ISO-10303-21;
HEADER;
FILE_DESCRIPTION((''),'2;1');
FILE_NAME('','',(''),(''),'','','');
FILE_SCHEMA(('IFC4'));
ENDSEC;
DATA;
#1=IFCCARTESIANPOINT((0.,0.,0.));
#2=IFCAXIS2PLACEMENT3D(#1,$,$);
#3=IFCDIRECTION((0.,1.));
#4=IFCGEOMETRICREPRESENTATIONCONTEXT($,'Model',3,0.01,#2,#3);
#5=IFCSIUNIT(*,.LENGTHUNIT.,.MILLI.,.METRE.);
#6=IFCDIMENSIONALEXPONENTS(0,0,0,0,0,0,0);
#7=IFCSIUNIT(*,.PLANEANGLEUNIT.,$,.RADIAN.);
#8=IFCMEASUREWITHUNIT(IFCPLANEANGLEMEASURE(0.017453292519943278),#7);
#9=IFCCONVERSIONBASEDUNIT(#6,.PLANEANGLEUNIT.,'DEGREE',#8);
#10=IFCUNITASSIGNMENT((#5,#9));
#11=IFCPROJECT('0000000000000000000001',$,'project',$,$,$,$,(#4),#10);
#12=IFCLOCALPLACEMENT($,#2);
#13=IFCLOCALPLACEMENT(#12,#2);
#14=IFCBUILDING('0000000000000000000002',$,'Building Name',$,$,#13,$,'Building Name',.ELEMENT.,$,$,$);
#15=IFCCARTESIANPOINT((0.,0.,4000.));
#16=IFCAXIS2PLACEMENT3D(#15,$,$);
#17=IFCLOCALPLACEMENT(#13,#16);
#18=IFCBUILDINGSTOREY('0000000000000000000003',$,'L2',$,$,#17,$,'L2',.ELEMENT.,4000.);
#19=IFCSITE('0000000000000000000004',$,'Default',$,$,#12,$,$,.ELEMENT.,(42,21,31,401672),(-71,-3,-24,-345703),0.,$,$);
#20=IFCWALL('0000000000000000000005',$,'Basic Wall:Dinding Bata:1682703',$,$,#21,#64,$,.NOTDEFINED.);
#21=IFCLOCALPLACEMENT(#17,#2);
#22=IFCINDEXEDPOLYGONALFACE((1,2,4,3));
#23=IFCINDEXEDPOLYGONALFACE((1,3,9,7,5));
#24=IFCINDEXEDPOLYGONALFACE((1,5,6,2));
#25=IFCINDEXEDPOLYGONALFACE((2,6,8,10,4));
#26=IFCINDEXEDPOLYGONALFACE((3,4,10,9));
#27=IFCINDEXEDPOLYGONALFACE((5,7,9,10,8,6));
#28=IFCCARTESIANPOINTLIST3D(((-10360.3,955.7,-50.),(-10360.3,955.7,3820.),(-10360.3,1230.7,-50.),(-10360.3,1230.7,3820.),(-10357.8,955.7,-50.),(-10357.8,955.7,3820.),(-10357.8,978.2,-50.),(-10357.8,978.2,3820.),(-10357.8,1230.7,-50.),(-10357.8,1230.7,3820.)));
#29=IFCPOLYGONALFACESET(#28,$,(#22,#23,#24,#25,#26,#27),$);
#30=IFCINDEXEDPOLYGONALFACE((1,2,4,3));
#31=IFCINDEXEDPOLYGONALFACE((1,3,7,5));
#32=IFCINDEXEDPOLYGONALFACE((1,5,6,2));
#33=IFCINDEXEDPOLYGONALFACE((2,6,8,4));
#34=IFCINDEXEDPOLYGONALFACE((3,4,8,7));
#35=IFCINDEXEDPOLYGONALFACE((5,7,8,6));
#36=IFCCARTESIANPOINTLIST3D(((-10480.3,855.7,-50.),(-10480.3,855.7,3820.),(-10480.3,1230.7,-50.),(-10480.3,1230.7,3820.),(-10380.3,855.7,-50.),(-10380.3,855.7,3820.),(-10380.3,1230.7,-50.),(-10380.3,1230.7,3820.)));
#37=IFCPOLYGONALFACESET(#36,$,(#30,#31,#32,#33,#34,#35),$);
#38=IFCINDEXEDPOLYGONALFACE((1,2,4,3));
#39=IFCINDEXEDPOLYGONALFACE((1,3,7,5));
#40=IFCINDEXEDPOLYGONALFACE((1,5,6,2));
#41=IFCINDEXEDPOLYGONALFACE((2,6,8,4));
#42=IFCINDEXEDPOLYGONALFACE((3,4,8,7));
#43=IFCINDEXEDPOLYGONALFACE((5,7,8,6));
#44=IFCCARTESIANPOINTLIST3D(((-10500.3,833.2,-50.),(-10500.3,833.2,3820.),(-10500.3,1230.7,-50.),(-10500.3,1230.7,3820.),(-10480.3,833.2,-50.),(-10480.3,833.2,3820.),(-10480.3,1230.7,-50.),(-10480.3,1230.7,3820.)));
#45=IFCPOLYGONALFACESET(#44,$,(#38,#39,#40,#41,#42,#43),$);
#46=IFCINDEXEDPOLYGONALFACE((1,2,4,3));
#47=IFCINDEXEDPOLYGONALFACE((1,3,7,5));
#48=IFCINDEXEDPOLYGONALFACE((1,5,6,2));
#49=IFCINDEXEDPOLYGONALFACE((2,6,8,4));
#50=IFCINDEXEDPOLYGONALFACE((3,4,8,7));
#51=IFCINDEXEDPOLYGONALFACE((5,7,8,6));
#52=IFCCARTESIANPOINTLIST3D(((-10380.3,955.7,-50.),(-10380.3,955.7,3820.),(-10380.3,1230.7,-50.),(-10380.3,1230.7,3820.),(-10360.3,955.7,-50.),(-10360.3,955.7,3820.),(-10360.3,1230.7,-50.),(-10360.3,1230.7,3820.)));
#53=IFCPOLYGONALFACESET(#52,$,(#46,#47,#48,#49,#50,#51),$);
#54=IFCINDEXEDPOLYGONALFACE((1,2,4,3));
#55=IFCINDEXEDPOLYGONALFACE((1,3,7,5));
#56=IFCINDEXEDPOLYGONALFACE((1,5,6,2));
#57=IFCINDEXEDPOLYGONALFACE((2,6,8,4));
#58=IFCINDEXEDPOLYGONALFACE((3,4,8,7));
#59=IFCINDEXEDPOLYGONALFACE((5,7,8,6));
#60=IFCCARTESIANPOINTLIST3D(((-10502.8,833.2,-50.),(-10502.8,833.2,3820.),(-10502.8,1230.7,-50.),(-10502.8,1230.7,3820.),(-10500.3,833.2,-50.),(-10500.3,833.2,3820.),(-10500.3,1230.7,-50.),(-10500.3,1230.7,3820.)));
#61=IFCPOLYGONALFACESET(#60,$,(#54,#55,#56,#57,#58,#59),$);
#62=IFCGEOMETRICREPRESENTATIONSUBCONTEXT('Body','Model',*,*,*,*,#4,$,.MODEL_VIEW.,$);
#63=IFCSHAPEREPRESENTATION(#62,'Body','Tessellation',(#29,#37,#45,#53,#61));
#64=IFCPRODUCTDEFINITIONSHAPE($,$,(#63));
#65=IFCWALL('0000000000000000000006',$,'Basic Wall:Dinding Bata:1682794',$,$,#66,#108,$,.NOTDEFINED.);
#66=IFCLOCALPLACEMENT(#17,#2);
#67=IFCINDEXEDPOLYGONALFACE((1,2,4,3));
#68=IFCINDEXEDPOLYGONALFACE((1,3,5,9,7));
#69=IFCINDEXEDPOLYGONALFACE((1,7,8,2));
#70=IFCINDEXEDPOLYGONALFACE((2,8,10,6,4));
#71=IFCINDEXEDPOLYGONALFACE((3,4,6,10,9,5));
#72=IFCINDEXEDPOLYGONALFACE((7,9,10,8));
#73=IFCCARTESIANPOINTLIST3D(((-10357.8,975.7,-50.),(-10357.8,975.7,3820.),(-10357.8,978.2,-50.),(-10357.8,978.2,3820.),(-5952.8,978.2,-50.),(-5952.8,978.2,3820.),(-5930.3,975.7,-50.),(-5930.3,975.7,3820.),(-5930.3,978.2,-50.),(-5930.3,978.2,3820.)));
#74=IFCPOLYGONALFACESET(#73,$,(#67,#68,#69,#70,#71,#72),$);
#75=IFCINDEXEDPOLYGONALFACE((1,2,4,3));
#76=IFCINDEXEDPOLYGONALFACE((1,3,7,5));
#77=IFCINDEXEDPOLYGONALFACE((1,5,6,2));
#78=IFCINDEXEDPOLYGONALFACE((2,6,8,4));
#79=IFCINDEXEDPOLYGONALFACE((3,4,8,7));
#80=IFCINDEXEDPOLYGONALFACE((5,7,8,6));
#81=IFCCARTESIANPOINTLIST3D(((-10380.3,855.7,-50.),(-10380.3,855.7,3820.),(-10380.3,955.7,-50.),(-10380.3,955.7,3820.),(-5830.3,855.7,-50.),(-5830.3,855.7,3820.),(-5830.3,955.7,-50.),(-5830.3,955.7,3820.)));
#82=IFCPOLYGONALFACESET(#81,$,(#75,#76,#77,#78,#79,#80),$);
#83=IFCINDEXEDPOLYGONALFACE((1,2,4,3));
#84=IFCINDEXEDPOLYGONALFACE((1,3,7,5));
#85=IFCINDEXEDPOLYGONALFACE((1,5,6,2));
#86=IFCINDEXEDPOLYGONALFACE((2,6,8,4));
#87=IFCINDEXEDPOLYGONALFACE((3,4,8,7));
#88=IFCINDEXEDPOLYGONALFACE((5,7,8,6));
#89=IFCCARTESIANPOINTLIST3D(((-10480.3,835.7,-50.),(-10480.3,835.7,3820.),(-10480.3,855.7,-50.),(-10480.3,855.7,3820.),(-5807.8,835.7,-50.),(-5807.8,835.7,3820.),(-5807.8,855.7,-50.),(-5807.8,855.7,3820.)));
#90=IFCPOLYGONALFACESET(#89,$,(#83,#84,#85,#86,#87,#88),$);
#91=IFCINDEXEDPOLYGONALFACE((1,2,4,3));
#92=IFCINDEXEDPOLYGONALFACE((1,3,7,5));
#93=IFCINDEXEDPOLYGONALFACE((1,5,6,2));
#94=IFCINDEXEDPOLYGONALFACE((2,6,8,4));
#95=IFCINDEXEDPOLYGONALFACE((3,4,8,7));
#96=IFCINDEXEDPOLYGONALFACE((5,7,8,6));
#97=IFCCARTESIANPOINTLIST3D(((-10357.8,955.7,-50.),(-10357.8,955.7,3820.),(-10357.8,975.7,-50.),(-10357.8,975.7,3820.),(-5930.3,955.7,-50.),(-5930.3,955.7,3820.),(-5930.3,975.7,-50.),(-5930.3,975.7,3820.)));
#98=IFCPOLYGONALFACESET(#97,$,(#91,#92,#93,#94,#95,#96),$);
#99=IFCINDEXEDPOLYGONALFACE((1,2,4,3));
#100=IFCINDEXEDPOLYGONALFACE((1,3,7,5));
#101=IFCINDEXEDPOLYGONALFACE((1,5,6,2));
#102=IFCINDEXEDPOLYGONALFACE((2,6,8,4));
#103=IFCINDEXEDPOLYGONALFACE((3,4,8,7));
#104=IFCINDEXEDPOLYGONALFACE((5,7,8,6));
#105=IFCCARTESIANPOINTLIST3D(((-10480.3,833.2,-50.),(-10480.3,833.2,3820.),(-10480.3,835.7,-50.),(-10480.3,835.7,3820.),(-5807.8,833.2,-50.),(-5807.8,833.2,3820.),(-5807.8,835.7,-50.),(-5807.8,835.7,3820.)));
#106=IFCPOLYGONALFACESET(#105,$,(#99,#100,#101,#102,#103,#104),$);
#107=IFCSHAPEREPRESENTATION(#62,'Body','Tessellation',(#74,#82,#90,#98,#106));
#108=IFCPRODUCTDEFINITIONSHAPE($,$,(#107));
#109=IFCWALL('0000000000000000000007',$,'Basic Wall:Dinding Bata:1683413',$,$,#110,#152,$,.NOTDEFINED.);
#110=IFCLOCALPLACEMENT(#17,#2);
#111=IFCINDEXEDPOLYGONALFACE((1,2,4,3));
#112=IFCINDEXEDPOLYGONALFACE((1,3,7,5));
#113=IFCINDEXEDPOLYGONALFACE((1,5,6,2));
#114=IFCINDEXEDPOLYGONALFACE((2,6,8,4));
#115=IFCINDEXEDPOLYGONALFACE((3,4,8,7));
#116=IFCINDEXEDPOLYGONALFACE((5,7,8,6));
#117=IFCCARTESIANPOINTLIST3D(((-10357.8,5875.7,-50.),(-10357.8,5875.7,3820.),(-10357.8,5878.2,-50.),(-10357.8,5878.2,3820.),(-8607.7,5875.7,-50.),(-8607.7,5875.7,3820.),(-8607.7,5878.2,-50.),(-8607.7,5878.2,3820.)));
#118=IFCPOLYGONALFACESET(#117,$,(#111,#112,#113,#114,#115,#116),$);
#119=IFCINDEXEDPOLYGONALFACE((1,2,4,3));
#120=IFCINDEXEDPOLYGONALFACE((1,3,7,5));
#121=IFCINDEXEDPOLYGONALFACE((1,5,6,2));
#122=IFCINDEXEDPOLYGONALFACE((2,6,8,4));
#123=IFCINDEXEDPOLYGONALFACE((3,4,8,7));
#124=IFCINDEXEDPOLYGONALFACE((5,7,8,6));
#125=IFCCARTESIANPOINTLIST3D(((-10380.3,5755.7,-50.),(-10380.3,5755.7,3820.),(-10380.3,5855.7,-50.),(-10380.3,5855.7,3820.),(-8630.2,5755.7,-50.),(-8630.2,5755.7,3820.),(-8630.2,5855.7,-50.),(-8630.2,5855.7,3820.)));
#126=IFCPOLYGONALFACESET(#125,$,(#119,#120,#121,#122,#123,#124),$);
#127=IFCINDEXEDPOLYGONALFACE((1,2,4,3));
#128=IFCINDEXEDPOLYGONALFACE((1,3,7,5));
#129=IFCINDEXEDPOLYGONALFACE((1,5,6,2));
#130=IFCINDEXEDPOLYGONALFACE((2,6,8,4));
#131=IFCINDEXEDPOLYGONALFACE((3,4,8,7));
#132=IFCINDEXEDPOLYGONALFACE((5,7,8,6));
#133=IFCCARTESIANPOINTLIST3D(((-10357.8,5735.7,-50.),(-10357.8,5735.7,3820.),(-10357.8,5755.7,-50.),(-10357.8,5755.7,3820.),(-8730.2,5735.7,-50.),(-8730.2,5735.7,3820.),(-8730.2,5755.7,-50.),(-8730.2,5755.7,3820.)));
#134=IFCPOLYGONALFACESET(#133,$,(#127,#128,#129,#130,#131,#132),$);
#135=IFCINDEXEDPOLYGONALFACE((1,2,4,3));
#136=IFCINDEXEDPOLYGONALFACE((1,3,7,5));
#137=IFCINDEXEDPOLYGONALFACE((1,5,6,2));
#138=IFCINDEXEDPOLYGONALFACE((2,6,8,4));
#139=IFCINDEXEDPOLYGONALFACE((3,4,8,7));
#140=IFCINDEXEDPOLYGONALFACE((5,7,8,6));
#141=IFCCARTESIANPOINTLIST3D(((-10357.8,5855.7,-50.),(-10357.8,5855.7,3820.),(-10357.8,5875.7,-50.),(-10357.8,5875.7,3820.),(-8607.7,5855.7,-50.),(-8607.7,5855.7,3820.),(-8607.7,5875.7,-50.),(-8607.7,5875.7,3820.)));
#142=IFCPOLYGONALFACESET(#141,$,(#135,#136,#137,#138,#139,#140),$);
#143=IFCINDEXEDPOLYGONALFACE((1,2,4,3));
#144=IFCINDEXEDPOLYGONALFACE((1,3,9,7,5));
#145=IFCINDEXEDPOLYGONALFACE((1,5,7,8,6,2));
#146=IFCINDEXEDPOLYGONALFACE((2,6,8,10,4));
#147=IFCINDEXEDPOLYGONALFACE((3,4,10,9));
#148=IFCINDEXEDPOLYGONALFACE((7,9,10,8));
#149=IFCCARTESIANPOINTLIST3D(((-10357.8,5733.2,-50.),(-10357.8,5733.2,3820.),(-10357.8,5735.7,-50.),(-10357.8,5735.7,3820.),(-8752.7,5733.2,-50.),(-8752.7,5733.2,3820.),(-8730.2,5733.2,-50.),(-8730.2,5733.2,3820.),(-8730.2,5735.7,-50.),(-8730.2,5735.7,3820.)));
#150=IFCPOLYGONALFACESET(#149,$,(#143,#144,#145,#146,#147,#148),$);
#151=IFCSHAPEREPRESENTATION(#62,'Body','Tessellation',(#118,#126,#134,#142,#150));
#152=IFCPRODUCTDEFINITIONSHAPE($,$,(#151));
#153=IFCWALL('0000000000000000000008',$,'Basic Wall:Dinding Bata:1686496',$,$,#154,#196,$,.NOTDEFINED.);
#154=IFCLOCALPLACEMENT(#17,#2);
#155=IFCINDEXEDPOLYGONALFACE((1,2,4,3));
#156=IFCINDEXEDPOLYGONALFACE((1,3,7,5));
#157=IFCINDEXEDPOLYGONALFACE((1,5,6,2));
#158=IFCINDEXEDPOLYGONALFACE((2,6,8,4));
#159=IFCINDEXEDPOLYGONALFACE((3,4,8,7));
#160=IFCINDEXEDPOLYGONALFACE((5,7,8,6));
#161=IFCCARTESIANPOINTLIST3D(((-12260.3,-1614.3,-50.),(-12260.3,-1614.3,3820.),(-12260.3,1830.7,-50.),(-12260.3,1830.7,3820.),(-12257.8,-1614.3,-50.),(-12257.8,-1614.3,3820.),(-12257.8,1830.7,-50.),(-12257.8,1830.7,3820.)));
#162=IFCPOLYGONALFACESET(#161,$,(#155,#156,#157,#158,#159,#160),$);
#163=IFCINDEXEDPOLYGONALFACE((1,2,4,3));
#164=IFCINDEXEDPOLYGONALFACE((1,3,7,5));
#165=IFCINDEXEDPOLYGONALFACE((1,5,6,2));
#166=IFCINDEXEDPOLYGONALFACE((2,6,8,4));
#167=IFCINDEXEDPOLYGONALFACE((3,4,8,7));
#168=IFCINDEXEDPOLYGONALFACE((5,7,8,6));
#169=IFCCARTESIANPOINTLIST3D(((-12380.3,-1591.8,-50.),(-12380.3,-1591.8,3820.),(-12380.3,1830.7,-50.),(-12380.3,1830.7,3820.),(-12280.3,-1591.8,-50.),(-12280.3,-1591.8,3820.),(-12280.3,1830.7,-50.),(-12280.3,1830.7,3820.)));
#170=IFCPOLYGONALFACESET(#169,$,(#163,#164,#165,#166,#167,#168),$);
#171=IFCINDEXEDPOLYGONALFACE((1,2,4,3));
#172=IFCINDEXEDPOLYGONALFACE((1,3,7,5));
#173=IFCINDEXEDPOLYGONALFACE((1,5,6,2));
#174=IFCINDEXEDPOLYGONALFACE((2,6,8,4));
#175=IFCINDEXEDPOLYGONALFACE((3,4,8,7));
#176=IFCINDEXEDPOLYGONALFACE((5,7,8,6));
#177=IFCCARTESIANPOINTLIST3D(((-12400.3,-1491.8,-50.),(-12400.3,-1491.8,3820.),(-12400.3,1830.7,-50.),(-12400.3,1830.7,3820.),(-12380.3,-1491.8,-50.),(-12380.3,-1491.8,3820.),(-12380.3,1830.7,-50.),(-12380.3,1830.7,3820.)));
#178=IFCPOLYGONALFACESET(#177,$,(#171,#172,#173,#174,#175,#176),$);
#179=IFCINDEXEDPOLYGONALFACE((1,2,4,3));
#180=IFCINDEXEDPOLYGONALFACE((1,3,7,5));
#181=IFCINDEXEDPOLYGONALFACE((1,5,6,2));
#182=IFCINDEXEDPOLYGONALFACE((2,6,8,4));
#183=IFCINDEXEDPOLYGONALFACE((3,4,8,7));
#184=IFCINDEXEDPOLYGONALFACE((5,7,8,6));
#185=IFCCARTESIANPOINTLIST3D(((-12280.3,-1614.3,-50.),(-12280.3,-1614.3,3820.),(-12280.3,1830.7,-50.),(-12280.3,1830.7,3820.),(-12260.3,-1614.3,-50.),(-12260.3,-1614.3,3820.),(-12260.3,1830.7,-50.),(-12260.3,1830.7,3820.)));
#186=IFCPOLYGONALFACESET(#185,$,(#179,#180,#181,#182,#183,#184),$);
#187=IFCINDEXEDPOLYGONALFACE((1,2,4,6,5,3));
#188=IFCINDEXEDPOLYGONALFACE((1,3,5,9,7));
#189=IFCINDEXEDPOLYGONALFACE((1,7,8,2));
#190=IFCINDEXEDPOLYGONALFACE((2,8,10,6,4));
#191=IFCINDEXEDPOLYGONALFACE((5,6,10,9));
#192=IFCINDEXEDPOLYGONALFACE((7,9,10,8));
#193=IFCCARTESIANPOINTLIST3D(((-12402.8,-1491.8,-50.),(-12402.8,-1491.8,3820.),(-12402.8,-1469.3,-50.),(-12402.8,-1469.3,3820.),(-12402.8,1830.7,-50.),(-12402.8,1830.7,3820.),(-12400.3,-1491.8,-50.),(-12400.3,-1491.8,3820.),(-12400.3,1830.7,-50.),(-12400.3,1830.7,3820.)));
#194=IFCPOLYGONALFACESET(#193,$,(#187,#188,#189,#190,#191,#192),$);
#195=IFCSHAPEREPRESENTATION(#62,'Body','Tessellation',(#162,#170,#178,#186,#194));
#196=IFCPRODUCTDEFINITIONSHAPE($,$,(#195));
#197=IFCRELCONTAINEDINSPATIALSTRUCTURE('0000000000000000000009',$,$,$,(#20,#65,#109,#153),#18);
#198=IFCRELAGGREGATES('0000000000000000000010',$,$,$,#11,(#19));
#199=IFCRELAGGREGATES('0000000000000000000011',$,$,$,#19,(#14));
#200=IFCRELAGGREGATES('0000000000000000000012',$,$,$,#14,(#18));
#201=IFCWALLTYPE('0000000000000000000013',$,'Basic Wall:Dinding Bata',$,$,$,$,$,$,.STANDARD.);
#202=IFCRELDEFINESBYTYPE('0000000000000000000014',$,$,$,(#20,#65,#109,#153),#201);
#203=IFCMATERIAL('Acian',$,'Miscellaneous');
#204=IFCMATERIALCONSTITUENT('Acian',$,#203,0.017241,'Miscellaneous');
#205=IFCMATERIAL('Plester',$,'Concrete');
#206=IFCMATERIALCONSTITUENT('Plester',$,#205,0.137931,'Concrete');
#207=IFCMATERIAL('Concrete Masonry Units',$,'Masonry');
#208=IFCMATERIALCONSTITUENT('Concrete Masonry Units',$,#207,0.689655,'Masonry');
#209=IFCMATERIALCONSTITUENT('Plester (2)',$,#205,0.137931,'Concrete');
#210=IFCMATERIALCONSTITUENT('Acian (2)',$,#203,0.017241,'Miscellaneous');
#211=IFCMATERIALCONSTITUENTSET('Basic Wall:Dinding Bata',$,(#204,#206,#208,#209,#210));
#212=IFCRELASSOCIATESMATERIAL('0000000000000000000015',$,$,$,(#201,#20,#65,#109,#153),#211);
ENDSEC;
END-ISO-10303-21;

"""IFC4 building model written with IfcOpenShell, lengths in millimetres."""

from ifc_helpers import new_model, entity, si_unit, converted_unit, direction, frame, origin, place, context, subcontext, project, spatial, indexed_curve, outline, extrude, material, constituent, constituent_set, type_object, element, save


model = new_model("IFC4")

# Units and contexts
model_context = context("Model", 3, precision=0.01, world=origin(), true_north=direction((0.0, 1.0)))
body_context = subcontext(model_context, "Body", "Model", "MODEL_VIEW")
ifc_project = project(units=[si_unit("LENGTHUNIT", "METRE", prefix="MILLI"), converted_unit("PLANEANGLEUNIT", "DEGREE", entity("IfcPlaneAngleMeasure", 0.017453292519943278), si_unit("PLANEANGLEUNIT", "RADIAN"), dimensions=[0, 0, 0, 0, 0, 0, 0])], contexts=[model_context])

# Site, building, storey
site_placement = place(None, origin())
site = spatial("IfcSite", under=ifc_project, at=site_placement, Name="Default", CompositionType="ELEMENT", RefLatitude=(42, 21, 31, 401672), RefLongitude=(-71, -3, -24, -345703), RefElevation=0.0)
building_placement = place(site_placement, origin())
building = spatial("IfcBuilding", under=site, at=building_placement, Name="Building Name", LongName="Building Name", CompositionType="ELEMENT")
storey_placement = place(building_placement, frame((0.0, 0.0, 4000.0)))
storey = spatial("IfcBuildingStorey", under=building, at=storey_placement, Name="L2", LongName="L2", CompositionType="ELEMENT", Elevation=4000.0)

# Walls
ifc_material_1 = material(Name="Acian", Category="Miscellaneous")
ifc_constituent_1 = constituent(ifc_material_1, Name="Acian", Category="Miscellaneous", fraction=0.017241)
ifc_material_2 = material(Name="Plester", Category="Concrete")
ifc_constituent_2 = constituent(ifc_material_2, Name="Plester", Category="Concrete", fraction=0.137931)
ifc_material_3 = material(Name="Concrete Masonry Units", Category="Masonry")
ifc_constituent_3 = constituent(ifc_material_3, Name="Concrete Masonry Units", Category="Masonry", fraction=0.689655)
ifc_constituent_4 = constituent(ifc_material_2, Name="Plester (2)", Category="Concrete", fraction=0.137931)
ifc_constituent_5 = constituent(ifc_material_1, Name="Acian (2)", Category="Miscellaneous", fraction=0.017241)
ifc_constituent_set = constituent_set(constituents=[ifc_constituent_1, ifc_constituent_2, ifc_constituent_3, ifc_constituent_4, ifc_constituent_5], Name="Basic Wall:Dinding Bata")
wall_type = type_object("IfcWallType", Name="Basic Wall:Dinding Bata", PredefinedType="STANDARD", material=ifc_constituent_set)
wall_1_placement = place(storey_placement, frame((-10430.3, 1230.7, -50.0), z_axis=(0.0, 0.0, 1.0), x_axis=(0.0, -1.0, 0.0)))
element("IfcWall", 1, at=wall_1_placement, inside=storey, type_object=wall_type, material=ifc_constituent_set, Name="Basic Wall:Dinding Bata:1682703", PredefinedType="NOTDEFINED", context=body_context, shape_type="SweptSolid", body=[
    extrude(outline(indexed_curve([(-92.0, -1.0), (160.5, -1.0), (160.5, 1.5), (-114.5, 1.5), (-114.5, -1.0), (-92.0, -1.0)], self_intersect=False)), frame((160.5, 71.5, 0.0), z_axis=(0.0, 0.0, 1.0), x_axis=(-1.0, 0.0, 0.0)), (0.0, 0.0, 1.0), 3870.0),
    extrude(outline(indexed_curve([(-187.5, -50.0), (187.5, -50.0), (187.5, 50.0), (-187.5, 50.0), (-187.5, -50.0)], self_intersect=False)), frame((187.5, 0.0, 0.0)), (0.0, 0.0, 1.0), 3870.0),
    extrude(outline(indexed_curve([(-198.7, -10.0), (198.7, -10.0), (198.7, 10.0), (-198.7, 10.0), (-198.7, -10.0)], self_intersect=False)), frame((198.7, -60.0, 0.0)), (0.0, 0.0, 1.0), 3870.0),
    extrude(outline(indexed_curve([(-137.5, -10.0), (137.5, -10.0), (137.5, 10.0), (-137.5, 10.0), (-137.5, -10.0)], self_intersect=False)), frame((137.5, 60.0, 0.0)), (0.0, 0.0, 1.0), 3870.0),
    extrude(outline(indexed_curve([(-1.2, -198.7), (1.2, -198.7), (1.2, 198.7), (-1.2, 198.7), (-1.2, -198.7)], self_intersect=False)), frame((198.7, -71.2, 0.0), z_axis=(0.0, 0.0, 1.0), x_axis=(0.0, 1.0, 0.0)), (0.0, 0.0, 1.0), 3870.0),
])
wall_2_placement = place(storey_placement, frame((-10357.8, 905.7, -50.0)))
element("IfcWall", 2, at=wall_2_placement, inside=storey, type_object=wall_type, material=ifc_constituent_set, Name="Basic Wall:Dinding Bata:1682794", PredefinedType="NOTDEFINED", context=body_context, shape_type="SweptSolid", body=[
    extrude(outline(indexed_curve([(-1753.0, -1.0), (2652.0, -1.0), (2652.0, 1.5), (-1775.5, 1.5), (-1775.5, -1.0), (-1753.0, -1.0)], self_intersect=False)), frame((2652.0, 71.5, 0.0), z_axis=(0.0, 0.0, 1.0), x_axis=(-1.0, 0.0, 0.0)), (0.0, 0.0, 1.0), 3870.0),
    extrude(outline(indexed_curve([(-2275.0, -50.0), (2275.0, -50.0), (2275.0, 50.0), (-2275.0, 50.0), (-2275.0, -50.0)], self_intersect=False)), frame((2252.5, 0.0, 0.0)), (0.0, 0.0, 1.0), 3870.0),
    extrude(outline(indexed_curve([(-2336.3, -10.0), (2336.3, -10.0), (2336.3, 10.0), (-2336.3, 10.0), (-2336.3, -10.0)], self_intersect=False)), frame((2213.8, -60.0, 0.0)), (0.0, 0.0, 1.0), 3870.0),
    extrude(outline(indexed_curve([(-2213.8, -10.0), (2213.8, -10.0), (2213.8, 10.0), (-2213.8, 10.0), (-2213.8, -10.0)], self_intersect=False)), frame((2213.8, 60.0, 0.0)), (0.0, 0.0, 1.0), 3870.0),
    extrude(outline(indexed_curve([(-1.3, -2336.3), (1.2, -2336.3), (1.3, 2336.3), (-1.2, 2336.3), (-1.3, -2336.3)], self_intersect=False)), frame((2213.8, -71.3, 0.0), z_axis=(0.0, 0.0, 1.0), x_axis=(0.0, 1.0, 0.0)), (0.0, 0.0, 1.0), 3870.0),
])
wall_3_placement = place(storey_placement, frame((-10357.8, 5805.7, -50.0)))
element("IfcWall", 3, at=wall_3_placement, inside=storey, type_object=wall_type, material=ifc_constituent_set, Name="Basic Wall:Dinding Bata:1683413", PredefinedType="NOTDEFINED", context=body_context, shape_type="SweptSolid", body=[
    extrude(outline(indexed_curve([(-1.3, -875.0), (1.2, -875.0), (1.3, 875.0), (-1.2, 875.0), (-1.3, -875.0)], self_intersect=False)), frame((875.0, 71.3, 0.0), z_axis=(0.0, 0.0, 1.0), x_axis=(0.0, -1.0, 0.0)), (0.0, 0.0, 1.0), 3870.0),
    extrude(outline(indexed_curve([(-875.0, -50.0), (875.0, -50.0), (875.0, 50.0), (-875.0, 50.0), (-875.0, -50.0)], self_intersect=False)), frame((852.5, 0.0, 0.0)), (0.0, 0.0, 1.0), 3870.0),
    extrude(outline(indexed_curve([(-813.8, -10.0), (813.8, -10.0), (813.8, 10.0), (-813.8, 10.0), (-813.8, -10.0)], self_intersect=False)), frame((813.8, -60.0, 0.0)), (0.0, 0.0, 1.0), 3870.0),
    extrude(outline(indexed_curve([(-875.0, -10.0), (875.0, -10.0), (875.0, 10.0), (-875.0, 10.0), (-875.0, -10.0)], self_intersect=False)), frame((875.0, 60.0, 0.0)), (0.0, 0.0, 1.0), 3870.0),
    extrude(outline(indexed_curve([(633.0, -1.0), (655.5, -1.0), (655.5, 1.5), (-972.0, 1.5), (-972.0, -1.0), (633.0, -1.0)], self_intersect=False)), frame((972.0, -71.5, 0.0)), (0.0, 0.0, 1.0), 3870.0),
])
wall_4_placement = place(storey_placement, frame((-12330.3, 1830.7, -50.0), z_axis=(0.0, 0.0, 1.0), x_axis=(0.0, -1.0, 0.0)))
element("IfcWall", 4, at=wall_4_placement, inside=storey, type_object=wall_type, material=ifc_constituent_set, Name="Basic Wall:Dinding Bata:1686496", PredefinedType="NOTDEFINED", context=body_context, shape_type="SweptSolid", body=[
    extrude(outline(indexed_curve([(-1.3, -1722.5), (1.2, -1722.5), (1.3, 1722.5), (-1.2, 1722.5), (-1.3, -1722.5)], self_intersect=False)), frame((1722.5, 71.3, 0.0), z_axis=(0.0, 0.0, 1.0), x_axis=(0.0, -1.0, 0.0)), (0.0, 0.0, 1.0), 3870.0),
    extrude(outline(indexed_curve([(-1711.3, -50.0), (1711.3, -50.0), (1711.3, 50.0), (-1711.3, 50.0), (-1711.3, -50.0)], self_intersect=False)), frame((1711.3, 0.0, 0.0)), (0.0, 0.0, 1.0), 3870.0),
    extrude(outline(indexed_curve([(-1661.3, -10.0), (1661.3, -10.0), (1661.3, 10.0), (-1661.3, 10.0), (-1661.3, -10.0)], self_intersect=False)), frame((1661.3, -60.0, 0.0)), (0.0, 0.0, 1.0), 3870.0),
    extrude(outline(indexed_curve([(-1722.5, -10.0), (1722.5, -10.0), (1722.5, 10.0), (-1722.5, 10.0), (-1722.5, -10.0)], self_intersect=False)), frame((1722.5, 60.0, 0.0)), (0.0, 0.0, 1.0), 3870.0),
    extrude(outline(indexed_curve([(1311.0, -1.0), (1333.5, -1.0), (1333.5, 1.5), (-1989.0, 1.5), (-1989.0, -1.0), (1311.0, -1.0)], self_intersect=False)), frame((1989.0, -71.5, 0.0)), (0.0, 0.0, 1.0), 3870.0),
])

save(model, "model.ifc")
